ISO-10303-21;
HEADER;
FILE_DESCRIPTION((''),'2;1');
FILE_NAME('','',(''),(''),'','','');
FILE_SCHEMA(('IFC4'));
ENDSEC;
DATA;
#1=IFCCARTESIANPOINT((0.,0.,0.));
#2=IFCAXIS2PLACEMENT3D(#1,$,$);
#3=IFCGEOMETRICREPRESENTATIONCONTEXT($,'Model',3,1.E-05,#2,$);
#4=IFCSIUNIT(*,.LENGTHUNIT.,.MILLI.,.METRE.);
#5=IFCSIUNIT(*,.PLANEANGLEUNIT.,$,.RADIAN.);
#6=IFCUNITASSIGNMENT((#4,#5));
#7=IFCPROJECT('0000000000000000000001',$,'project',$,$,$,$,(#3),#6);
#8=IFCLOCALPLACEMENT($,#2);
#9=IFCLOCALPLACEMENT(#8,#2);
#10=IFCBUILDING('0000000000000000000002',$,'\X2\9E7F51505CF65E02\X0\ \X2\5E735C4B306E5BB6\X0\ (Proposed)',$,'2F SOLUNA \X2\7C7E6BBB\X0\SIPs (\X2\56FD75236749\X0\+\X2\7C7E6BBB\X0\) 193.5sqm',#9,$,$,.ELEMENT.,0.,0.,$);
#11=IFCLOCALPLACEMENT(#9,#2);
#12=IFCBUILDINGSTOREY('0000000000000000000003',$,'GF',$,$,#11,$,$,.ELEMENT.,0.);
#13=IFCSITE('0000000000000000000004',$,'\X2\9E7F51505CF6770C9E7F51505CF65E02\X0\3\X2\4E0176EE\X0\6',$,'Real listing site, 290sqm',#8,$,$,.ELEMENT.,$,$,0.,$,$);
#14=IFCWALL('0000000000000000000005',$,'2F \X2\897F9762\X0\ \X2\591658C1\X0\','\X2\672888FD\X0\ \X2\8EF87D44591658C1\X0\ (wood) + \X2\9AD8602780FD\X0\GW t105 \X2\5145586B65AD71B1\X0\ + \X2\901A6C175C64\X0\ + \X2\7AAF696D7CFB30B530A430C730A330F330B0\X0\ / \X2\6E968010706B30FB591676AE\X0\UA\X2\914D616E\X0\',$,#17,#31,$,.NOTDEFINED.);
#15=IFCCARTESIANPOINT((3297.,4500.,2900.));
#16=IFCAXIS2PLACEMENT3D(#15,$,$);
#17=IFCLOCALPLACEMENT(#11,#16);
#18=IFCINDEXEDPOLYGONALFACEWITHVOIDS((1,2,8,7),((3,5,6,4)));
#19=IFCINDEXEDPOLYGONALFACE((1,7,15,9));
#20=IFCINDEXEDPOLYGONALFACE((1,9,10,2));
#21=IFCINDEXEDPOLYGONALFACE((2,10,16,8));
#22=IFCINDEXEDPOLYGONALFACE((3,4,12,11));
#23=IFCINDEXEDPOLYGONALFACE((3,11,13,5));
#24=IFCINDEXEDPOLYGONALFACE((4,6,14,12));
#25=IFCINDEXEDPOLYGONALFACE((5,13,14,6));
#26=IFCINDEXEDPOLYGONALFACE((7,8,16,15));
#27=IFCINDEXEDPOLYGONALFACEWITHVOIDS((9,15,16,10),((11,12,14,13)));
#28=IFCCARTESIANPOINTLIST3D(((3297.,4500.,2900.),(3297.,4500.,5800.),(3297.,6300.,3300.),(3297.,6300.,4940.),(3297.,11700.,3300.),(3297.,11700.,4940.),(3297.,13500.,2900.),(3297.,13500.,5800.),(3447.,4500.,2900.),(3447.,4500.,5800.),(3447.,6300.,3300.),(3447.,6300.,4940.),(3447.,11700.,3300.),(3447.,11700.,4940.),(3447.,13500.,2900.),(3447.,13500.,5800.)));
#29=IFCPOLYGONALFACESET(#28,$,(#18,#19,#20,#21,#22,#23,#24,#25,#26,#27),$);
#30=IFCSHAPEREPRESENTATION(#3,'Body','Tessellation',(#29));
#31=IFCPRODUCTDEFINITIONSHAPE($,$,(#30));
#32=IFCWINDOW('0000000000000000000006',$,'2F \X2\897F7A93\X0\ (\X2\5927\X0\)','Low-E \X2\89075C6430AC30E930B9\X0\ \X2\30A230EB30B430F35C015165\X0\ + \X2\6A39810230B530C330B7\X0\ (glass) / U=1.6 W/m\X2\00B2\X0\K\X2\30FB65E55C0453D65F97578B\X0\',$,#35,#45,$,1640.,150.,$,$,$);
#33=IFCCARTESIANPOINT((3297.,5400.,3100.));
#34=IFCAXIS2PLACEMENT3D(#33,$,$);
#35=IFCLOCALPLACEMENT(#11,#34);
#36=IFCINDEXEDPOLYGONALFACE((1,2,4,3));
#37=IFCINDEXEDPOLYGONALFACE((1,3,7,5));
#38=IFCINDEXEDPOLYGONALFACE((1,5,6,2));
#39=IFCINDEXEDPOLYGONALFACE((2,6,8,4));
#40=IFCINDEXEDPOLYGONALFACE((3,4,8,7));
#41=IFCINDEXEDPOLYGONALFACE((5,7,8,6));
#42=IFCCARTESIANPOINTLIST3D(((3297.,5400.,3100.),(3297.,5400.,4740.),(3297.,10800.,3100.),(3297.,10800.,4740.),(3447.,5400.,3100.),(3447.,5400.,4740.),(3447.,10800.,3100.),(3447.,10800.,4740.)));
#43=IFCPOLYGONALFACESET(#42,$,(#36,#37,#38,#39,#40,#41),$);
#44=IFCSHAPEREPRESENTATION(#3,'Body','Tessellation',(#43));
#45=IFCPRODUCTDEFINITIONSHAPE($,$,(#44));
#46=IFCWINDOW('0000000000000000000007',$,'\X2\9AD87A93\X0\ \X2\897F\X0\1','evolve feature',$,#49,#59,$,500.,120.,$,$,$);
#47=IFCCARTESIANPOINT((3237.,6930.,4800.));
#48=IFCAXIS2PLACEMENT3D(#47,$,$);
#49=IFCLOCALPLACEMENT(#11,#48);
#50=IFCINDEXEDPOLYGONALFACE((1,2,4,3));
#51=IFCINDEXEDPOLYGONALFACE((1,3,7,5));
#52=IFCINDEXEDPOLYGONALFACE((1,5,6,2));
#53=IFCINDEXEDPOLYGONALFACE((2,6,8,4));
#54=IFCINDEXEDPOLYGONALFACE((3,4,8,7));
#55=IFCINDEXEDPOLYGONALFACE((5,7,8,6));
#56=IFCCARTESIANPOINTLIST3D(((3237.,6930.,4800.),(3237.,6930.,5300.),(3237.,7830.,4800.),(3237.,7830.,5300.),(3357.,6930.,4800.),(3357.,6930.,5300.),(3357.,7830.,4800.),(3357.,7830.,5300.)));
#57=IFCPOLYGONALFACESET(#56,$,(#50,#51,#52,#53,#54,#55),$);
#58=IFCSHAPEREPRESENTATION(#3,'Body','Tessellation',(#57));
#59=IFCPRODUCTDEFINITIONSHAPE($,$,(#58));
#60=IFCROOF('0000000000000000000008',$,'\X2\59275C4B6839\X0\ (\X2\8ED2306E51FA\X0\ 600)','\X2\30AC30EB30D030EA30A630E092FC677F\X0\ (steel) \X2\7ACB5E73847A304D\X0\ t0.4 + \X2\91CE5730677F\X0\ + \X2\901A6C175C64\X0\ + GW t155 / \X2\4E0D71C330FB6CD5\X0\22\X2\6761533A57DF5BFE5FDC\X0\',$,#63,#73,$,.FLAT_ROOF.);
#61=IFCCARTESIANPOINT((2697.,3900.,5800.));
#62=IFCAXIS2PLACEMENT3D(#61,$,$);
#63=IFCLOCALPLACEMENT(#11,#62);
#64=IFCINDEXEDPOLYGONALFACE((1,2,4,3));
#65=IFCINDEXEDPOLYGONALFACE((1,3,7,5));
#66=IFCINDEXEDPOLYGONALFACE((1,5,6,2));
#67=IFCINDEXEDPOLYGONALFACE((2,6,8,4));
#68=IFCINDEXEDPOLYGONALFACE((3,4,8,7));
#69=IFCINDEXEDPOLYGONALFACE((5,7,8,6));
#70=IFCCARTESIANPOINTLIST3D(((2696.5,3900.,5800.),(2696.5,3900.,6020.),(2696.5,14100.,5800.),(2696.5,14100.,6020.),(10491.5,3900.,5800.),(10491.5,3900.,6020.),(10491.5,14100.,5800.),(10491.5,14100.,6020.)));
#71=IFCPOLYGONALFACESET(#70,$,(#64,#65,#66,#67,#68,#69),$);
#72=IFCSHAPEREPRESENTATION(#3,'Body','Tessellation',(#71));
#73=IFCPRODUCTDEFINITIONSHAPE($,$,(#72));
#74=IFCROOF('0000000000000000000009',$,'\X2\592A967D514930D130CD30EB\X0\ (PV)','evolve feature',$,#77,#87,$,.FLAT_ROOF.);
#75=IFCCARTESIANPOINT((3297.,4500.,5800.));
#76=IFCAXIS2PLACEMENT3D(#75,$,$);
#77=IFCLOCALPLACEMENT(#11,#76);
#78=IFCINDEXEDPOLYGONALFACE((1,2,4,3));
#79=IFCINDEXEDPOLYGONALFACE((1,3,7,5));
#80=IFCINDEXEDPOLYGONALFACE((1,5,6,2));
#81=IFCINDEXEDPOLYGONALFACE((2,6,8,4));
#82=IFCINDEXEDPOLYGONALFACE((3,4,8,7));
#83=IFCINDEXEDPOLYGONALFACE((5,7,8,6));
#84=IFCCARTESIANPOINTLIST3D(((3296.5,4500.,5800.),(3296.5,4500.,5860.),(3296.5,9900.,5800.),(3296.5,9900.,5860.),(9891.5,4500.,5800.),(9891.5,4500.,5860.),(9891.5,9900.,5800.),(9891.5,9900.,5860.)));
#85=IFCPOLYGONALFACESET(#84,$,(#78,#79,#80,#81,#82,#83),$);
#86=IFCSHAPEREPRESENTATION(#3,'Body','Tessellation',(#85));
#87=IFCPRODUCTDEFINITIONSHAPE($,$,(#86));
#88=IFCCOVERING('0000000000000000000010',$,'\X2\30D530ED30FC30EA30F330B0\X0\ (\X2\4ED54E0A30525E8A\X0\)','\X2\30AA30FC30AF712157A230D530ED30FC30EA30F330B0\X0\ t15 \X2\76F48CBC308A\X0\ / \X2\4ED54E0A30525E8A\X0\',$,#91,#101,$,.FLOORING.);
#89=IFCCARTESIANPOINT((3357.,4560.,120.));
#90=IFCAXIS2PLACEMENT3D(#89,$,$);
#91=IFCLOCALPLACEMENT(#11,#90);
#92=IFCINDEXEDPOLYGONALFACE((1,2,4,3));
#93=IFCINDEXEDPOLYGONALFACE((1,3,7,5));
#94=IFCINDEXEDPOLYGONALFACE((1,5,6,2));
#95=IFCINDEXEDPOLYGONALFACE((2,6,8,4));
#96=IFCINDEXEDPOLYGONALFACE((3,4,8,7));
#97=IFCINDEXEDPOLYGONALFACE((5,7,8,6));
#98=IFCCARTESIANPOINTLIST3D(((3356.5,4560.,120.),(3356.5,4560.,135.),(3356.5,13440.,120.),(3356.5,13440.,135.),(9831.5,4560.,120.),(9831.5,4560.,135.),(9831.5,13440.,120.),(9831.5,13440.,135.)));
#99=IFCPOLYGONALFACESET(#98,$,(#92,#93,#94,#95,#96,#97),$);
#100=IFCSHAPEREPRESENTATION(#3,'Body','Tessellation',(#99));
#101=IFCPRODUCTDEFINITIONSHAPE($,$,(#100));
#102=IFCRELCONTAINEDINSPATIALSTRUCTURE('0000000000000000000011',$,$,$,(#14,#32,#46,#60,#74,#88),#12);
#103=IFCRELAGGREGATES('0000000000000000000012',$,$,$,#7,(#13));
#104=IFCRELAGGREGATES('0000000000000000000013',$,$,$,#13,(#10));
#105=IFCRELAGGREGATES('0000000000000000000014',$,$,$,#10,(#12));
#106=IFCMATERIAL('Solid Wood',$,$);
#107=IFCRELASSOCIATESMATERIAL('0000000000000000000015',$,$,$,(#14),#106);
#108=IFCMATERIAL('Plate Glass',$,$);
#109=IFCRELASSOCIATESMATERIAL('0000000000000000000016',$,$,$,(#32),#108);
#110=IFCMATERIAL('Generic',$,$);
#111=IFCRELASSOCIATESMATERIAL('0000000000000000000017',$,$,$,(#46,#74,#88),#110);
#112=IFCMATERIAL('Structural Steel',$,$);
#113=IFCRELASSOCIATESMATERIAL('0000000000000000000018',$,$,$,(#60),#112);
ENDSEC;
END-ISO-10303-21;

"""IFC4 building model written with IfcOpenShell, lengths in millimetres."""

from ifc_helpers import new_model, si_unit, frame, frame_2d, origin, place, context, project, spatial, rectangle, extrude, material, element, fill, save


model = new_model("IFC4")

# Units and contexts
model_context = context("Model", 3, precision=1e-05, world=origin())
ifc_project = project(units=[si_unit("LENGTHUNIT", "METRE", prefix="MILLI"), si_unit("PLANEANGLEUNIT", "RADIAN")], contexts=[model_context])

# Site, building, storey
site_placement = place(None, origin())
site = spatial("IfcSite", under=ifc_project, at=site_placement, Name="鹿児島県鹿児島市3丁目6", ObjectType="Real listing site, 290sqm", CompositionType="ELEMENT", RefElevation=0.0)
building_placement = place(site_placement, origin())
building = spatial("IfcBuilding", under=site, at=building_placement, Name="鹿児島市 平屋の家 (Proposed)", ObjectType="2F SOLUNA 籾殻SIPs (国産杉+籾殻) 193.5sqm", CompositionType="ELEMENT", ElevationOfRefHeight=0.0, ElevationOfTerrain=0.0)
storey_placement = place(building_placement, origin())
storey = spatial("IfcBuildingStorey", under=building, at=storey_placement, Name="GF", CompositionType="ELEMENT", Elevation=0.0)

# Shared definitions
ifc_material_1 = material(Name="Solid Wood")

# Shared definitions
ifc_material_2 = material(Name="Plate Glass")
ifc_material_3 = material(Name="Generic")

# Wall, openings, windows
wall_1_placement = place(storey_placement, frame((3297.0, 4500.0, 2900.0)))
wall_1 = element("IfcWall", 1, at=wall_1_placement, inside=storey, material=ifc_material_1, Name="2F 西面 外壁", Description="木製 軸組外壁 (wood) + 高性能GW t105 充填断熱 + 通気層 + 窯業系サイディング / 準耐火・外皮UA配慮", PredefinedType="NOTDEFINED", context=model_context, shape_type="SweptSolid", body=[
    extrude(rectangle(XDim=150.0, YDim=9000.0, at=frame_2d((75.0, 4500.0))), frame((3297.0, 4500.0, 2900.0)), (0.0, 0.0, 1.0), 2900.0),
])
opening_1_placement = place(storey_placement, frame((3297.0, 5400.0, 3100.0)))
opening_1 = element("IfcOpeningElement", 2, at=opening_1_placement, cuts=wall_1, PredefinedType="NOTDEFINED", context=model_context, shape_type="SweptSolid", body=[
    extrude(rectangle(XDim=150.0, YDim=5400.0, at=frame_2d((75.0, 2700.0))), frame((3297.0, 5400.0, 3100.0)), (0.0, 0.0, 1.0), 1640.0),
])
opening_2_placement = place(storey_placement, frame((3237.0, 6930.0, 4800.0)))
opening_2 = element("IfcOpeningElement", 3, at=opening_2_placement, cuts=wall_1, PredefinedType="NOTDEFINED", context=model_context, shape_type="SweptSolid", body=[
    extrude(rectangle(XDim=120.0, YDim=900.0, at=frame_2d((60.0, 450.0))), frame((3237.0, 6930.0, 4800.0)), (0.0, 0.0, 1.0), 500.0),
])
window_1_placement = place(storey_placement, frame((3297.0, 5400.0, 3100.0)))
window_1 = element("IfcWindow", 4, at=window_1_placement, inside=storey, material=ifc_material_2, Name="2F 西窓 (大)", Description="Low-E 複層ガラス アルゴン封入 + 樹脂サッシ (glass) / U=1.6 W/m²K・日射取得型", OverallHeight=1640.0, OverallWidth=150.0, context=model_context, shape_type="SweptSolid", body=[
    extrude(rectangle(XDim=150.0, YDim=5400.0, at=frame_2d((75.0, 2700.0))), frame((3297.0, 5400.0, 3100.0)), (0.0, 0.0, 1.0), 1640.0),
])
fill(opening_1, window_1)
window_2_placement = place(storey_placement, frame((3237.0, 6930.0, 4800.0)))
window_2 = element("IfcWindow", 5, at=window_2_placement, inside=storey, material=ifc_material_3, Name="高窓 西1", Description="evolve feature", OverallHeight=500.0, OverallWidth=120.0, context=model_context, shape_type="SweptSolid", body=[
    extrude(rectangle(XDim=120.0, YDim=900.0, at=frame_2d((60.0, 450.0))), frame((3237.0, 6930.0, 4800.0)), (0.0, 0.0, 1.0), 500.0),
])
fill(opening_2, window_2)

# Roofs
ifc_material_4 = material(Name="Structural Steel")
roof_1_placement = place(storey_placement, frame((2697.0, 3900.0, 5800.0)))
element("IfcRoof", 6, at=roof_1_placement, inside=storey, material=ifc_material_4, Name="大屋根 (軒の出 600)", Description="ガルバリウム鋼板 (steel) 立平葺き t0.4 + 野地板 + 通気層 + GW t155 / 不燃・法22条区域対応", PredefinedType="FLAT_ROOF", context=model_context, shape_type="SweptSolid", body=[
    extrude(rectangle(XDim=7795.0, YDim=10200.0, at=frame_2d((3897.0, 5100.0))), frame((2697.0, 3900.0, 5800.0)), (0.0, 0.0, 1.0), 220.0),
])
roof_2_placement = place(storey_placement, frame((3297.0, 4500.0, 5800.0)))
element("IfcRoof", 7, at=roof_2_placement, inside=storey, material=ifc_material_3, Name="太陽光パネル (PV)", Description="evolve feature", PredefinedType="FLAT_ROOF", context=model_context, shape_type="SweptSolid", body=[
    extrude(rectangle(XDim=6595.0, YDim=5400.0, at=frame_2d((3297.0, 2700.0))), frame((3297.0, 4500.0, 5800.0)), (0.0, 0.0, 1.0), 60.0),
])

# Covering
covering_placement = place(storey_placement, frame((3357.0, 4560.0, 120.0)))
element("IfcCovering", 8, at=covering_placement, inside=storey, material=ifc_material_3, Name="フローリング (仕上げ床)", Description="オーク無垢フローリング t15 直貼り / 仕上げ床", PredefinedType="FLOORING", context=model_context, shape_type="SweptSolid", body=[
    extrude(rectangle(XDim=6475.0, YDim=8880.0, at=frame_2d((3237.0, 4440.0))), frame((3357.0, 4560.0, 120.0)), (0.0, 0.0, 1.0), 15.0),
])

save(model, "model.ifc")
